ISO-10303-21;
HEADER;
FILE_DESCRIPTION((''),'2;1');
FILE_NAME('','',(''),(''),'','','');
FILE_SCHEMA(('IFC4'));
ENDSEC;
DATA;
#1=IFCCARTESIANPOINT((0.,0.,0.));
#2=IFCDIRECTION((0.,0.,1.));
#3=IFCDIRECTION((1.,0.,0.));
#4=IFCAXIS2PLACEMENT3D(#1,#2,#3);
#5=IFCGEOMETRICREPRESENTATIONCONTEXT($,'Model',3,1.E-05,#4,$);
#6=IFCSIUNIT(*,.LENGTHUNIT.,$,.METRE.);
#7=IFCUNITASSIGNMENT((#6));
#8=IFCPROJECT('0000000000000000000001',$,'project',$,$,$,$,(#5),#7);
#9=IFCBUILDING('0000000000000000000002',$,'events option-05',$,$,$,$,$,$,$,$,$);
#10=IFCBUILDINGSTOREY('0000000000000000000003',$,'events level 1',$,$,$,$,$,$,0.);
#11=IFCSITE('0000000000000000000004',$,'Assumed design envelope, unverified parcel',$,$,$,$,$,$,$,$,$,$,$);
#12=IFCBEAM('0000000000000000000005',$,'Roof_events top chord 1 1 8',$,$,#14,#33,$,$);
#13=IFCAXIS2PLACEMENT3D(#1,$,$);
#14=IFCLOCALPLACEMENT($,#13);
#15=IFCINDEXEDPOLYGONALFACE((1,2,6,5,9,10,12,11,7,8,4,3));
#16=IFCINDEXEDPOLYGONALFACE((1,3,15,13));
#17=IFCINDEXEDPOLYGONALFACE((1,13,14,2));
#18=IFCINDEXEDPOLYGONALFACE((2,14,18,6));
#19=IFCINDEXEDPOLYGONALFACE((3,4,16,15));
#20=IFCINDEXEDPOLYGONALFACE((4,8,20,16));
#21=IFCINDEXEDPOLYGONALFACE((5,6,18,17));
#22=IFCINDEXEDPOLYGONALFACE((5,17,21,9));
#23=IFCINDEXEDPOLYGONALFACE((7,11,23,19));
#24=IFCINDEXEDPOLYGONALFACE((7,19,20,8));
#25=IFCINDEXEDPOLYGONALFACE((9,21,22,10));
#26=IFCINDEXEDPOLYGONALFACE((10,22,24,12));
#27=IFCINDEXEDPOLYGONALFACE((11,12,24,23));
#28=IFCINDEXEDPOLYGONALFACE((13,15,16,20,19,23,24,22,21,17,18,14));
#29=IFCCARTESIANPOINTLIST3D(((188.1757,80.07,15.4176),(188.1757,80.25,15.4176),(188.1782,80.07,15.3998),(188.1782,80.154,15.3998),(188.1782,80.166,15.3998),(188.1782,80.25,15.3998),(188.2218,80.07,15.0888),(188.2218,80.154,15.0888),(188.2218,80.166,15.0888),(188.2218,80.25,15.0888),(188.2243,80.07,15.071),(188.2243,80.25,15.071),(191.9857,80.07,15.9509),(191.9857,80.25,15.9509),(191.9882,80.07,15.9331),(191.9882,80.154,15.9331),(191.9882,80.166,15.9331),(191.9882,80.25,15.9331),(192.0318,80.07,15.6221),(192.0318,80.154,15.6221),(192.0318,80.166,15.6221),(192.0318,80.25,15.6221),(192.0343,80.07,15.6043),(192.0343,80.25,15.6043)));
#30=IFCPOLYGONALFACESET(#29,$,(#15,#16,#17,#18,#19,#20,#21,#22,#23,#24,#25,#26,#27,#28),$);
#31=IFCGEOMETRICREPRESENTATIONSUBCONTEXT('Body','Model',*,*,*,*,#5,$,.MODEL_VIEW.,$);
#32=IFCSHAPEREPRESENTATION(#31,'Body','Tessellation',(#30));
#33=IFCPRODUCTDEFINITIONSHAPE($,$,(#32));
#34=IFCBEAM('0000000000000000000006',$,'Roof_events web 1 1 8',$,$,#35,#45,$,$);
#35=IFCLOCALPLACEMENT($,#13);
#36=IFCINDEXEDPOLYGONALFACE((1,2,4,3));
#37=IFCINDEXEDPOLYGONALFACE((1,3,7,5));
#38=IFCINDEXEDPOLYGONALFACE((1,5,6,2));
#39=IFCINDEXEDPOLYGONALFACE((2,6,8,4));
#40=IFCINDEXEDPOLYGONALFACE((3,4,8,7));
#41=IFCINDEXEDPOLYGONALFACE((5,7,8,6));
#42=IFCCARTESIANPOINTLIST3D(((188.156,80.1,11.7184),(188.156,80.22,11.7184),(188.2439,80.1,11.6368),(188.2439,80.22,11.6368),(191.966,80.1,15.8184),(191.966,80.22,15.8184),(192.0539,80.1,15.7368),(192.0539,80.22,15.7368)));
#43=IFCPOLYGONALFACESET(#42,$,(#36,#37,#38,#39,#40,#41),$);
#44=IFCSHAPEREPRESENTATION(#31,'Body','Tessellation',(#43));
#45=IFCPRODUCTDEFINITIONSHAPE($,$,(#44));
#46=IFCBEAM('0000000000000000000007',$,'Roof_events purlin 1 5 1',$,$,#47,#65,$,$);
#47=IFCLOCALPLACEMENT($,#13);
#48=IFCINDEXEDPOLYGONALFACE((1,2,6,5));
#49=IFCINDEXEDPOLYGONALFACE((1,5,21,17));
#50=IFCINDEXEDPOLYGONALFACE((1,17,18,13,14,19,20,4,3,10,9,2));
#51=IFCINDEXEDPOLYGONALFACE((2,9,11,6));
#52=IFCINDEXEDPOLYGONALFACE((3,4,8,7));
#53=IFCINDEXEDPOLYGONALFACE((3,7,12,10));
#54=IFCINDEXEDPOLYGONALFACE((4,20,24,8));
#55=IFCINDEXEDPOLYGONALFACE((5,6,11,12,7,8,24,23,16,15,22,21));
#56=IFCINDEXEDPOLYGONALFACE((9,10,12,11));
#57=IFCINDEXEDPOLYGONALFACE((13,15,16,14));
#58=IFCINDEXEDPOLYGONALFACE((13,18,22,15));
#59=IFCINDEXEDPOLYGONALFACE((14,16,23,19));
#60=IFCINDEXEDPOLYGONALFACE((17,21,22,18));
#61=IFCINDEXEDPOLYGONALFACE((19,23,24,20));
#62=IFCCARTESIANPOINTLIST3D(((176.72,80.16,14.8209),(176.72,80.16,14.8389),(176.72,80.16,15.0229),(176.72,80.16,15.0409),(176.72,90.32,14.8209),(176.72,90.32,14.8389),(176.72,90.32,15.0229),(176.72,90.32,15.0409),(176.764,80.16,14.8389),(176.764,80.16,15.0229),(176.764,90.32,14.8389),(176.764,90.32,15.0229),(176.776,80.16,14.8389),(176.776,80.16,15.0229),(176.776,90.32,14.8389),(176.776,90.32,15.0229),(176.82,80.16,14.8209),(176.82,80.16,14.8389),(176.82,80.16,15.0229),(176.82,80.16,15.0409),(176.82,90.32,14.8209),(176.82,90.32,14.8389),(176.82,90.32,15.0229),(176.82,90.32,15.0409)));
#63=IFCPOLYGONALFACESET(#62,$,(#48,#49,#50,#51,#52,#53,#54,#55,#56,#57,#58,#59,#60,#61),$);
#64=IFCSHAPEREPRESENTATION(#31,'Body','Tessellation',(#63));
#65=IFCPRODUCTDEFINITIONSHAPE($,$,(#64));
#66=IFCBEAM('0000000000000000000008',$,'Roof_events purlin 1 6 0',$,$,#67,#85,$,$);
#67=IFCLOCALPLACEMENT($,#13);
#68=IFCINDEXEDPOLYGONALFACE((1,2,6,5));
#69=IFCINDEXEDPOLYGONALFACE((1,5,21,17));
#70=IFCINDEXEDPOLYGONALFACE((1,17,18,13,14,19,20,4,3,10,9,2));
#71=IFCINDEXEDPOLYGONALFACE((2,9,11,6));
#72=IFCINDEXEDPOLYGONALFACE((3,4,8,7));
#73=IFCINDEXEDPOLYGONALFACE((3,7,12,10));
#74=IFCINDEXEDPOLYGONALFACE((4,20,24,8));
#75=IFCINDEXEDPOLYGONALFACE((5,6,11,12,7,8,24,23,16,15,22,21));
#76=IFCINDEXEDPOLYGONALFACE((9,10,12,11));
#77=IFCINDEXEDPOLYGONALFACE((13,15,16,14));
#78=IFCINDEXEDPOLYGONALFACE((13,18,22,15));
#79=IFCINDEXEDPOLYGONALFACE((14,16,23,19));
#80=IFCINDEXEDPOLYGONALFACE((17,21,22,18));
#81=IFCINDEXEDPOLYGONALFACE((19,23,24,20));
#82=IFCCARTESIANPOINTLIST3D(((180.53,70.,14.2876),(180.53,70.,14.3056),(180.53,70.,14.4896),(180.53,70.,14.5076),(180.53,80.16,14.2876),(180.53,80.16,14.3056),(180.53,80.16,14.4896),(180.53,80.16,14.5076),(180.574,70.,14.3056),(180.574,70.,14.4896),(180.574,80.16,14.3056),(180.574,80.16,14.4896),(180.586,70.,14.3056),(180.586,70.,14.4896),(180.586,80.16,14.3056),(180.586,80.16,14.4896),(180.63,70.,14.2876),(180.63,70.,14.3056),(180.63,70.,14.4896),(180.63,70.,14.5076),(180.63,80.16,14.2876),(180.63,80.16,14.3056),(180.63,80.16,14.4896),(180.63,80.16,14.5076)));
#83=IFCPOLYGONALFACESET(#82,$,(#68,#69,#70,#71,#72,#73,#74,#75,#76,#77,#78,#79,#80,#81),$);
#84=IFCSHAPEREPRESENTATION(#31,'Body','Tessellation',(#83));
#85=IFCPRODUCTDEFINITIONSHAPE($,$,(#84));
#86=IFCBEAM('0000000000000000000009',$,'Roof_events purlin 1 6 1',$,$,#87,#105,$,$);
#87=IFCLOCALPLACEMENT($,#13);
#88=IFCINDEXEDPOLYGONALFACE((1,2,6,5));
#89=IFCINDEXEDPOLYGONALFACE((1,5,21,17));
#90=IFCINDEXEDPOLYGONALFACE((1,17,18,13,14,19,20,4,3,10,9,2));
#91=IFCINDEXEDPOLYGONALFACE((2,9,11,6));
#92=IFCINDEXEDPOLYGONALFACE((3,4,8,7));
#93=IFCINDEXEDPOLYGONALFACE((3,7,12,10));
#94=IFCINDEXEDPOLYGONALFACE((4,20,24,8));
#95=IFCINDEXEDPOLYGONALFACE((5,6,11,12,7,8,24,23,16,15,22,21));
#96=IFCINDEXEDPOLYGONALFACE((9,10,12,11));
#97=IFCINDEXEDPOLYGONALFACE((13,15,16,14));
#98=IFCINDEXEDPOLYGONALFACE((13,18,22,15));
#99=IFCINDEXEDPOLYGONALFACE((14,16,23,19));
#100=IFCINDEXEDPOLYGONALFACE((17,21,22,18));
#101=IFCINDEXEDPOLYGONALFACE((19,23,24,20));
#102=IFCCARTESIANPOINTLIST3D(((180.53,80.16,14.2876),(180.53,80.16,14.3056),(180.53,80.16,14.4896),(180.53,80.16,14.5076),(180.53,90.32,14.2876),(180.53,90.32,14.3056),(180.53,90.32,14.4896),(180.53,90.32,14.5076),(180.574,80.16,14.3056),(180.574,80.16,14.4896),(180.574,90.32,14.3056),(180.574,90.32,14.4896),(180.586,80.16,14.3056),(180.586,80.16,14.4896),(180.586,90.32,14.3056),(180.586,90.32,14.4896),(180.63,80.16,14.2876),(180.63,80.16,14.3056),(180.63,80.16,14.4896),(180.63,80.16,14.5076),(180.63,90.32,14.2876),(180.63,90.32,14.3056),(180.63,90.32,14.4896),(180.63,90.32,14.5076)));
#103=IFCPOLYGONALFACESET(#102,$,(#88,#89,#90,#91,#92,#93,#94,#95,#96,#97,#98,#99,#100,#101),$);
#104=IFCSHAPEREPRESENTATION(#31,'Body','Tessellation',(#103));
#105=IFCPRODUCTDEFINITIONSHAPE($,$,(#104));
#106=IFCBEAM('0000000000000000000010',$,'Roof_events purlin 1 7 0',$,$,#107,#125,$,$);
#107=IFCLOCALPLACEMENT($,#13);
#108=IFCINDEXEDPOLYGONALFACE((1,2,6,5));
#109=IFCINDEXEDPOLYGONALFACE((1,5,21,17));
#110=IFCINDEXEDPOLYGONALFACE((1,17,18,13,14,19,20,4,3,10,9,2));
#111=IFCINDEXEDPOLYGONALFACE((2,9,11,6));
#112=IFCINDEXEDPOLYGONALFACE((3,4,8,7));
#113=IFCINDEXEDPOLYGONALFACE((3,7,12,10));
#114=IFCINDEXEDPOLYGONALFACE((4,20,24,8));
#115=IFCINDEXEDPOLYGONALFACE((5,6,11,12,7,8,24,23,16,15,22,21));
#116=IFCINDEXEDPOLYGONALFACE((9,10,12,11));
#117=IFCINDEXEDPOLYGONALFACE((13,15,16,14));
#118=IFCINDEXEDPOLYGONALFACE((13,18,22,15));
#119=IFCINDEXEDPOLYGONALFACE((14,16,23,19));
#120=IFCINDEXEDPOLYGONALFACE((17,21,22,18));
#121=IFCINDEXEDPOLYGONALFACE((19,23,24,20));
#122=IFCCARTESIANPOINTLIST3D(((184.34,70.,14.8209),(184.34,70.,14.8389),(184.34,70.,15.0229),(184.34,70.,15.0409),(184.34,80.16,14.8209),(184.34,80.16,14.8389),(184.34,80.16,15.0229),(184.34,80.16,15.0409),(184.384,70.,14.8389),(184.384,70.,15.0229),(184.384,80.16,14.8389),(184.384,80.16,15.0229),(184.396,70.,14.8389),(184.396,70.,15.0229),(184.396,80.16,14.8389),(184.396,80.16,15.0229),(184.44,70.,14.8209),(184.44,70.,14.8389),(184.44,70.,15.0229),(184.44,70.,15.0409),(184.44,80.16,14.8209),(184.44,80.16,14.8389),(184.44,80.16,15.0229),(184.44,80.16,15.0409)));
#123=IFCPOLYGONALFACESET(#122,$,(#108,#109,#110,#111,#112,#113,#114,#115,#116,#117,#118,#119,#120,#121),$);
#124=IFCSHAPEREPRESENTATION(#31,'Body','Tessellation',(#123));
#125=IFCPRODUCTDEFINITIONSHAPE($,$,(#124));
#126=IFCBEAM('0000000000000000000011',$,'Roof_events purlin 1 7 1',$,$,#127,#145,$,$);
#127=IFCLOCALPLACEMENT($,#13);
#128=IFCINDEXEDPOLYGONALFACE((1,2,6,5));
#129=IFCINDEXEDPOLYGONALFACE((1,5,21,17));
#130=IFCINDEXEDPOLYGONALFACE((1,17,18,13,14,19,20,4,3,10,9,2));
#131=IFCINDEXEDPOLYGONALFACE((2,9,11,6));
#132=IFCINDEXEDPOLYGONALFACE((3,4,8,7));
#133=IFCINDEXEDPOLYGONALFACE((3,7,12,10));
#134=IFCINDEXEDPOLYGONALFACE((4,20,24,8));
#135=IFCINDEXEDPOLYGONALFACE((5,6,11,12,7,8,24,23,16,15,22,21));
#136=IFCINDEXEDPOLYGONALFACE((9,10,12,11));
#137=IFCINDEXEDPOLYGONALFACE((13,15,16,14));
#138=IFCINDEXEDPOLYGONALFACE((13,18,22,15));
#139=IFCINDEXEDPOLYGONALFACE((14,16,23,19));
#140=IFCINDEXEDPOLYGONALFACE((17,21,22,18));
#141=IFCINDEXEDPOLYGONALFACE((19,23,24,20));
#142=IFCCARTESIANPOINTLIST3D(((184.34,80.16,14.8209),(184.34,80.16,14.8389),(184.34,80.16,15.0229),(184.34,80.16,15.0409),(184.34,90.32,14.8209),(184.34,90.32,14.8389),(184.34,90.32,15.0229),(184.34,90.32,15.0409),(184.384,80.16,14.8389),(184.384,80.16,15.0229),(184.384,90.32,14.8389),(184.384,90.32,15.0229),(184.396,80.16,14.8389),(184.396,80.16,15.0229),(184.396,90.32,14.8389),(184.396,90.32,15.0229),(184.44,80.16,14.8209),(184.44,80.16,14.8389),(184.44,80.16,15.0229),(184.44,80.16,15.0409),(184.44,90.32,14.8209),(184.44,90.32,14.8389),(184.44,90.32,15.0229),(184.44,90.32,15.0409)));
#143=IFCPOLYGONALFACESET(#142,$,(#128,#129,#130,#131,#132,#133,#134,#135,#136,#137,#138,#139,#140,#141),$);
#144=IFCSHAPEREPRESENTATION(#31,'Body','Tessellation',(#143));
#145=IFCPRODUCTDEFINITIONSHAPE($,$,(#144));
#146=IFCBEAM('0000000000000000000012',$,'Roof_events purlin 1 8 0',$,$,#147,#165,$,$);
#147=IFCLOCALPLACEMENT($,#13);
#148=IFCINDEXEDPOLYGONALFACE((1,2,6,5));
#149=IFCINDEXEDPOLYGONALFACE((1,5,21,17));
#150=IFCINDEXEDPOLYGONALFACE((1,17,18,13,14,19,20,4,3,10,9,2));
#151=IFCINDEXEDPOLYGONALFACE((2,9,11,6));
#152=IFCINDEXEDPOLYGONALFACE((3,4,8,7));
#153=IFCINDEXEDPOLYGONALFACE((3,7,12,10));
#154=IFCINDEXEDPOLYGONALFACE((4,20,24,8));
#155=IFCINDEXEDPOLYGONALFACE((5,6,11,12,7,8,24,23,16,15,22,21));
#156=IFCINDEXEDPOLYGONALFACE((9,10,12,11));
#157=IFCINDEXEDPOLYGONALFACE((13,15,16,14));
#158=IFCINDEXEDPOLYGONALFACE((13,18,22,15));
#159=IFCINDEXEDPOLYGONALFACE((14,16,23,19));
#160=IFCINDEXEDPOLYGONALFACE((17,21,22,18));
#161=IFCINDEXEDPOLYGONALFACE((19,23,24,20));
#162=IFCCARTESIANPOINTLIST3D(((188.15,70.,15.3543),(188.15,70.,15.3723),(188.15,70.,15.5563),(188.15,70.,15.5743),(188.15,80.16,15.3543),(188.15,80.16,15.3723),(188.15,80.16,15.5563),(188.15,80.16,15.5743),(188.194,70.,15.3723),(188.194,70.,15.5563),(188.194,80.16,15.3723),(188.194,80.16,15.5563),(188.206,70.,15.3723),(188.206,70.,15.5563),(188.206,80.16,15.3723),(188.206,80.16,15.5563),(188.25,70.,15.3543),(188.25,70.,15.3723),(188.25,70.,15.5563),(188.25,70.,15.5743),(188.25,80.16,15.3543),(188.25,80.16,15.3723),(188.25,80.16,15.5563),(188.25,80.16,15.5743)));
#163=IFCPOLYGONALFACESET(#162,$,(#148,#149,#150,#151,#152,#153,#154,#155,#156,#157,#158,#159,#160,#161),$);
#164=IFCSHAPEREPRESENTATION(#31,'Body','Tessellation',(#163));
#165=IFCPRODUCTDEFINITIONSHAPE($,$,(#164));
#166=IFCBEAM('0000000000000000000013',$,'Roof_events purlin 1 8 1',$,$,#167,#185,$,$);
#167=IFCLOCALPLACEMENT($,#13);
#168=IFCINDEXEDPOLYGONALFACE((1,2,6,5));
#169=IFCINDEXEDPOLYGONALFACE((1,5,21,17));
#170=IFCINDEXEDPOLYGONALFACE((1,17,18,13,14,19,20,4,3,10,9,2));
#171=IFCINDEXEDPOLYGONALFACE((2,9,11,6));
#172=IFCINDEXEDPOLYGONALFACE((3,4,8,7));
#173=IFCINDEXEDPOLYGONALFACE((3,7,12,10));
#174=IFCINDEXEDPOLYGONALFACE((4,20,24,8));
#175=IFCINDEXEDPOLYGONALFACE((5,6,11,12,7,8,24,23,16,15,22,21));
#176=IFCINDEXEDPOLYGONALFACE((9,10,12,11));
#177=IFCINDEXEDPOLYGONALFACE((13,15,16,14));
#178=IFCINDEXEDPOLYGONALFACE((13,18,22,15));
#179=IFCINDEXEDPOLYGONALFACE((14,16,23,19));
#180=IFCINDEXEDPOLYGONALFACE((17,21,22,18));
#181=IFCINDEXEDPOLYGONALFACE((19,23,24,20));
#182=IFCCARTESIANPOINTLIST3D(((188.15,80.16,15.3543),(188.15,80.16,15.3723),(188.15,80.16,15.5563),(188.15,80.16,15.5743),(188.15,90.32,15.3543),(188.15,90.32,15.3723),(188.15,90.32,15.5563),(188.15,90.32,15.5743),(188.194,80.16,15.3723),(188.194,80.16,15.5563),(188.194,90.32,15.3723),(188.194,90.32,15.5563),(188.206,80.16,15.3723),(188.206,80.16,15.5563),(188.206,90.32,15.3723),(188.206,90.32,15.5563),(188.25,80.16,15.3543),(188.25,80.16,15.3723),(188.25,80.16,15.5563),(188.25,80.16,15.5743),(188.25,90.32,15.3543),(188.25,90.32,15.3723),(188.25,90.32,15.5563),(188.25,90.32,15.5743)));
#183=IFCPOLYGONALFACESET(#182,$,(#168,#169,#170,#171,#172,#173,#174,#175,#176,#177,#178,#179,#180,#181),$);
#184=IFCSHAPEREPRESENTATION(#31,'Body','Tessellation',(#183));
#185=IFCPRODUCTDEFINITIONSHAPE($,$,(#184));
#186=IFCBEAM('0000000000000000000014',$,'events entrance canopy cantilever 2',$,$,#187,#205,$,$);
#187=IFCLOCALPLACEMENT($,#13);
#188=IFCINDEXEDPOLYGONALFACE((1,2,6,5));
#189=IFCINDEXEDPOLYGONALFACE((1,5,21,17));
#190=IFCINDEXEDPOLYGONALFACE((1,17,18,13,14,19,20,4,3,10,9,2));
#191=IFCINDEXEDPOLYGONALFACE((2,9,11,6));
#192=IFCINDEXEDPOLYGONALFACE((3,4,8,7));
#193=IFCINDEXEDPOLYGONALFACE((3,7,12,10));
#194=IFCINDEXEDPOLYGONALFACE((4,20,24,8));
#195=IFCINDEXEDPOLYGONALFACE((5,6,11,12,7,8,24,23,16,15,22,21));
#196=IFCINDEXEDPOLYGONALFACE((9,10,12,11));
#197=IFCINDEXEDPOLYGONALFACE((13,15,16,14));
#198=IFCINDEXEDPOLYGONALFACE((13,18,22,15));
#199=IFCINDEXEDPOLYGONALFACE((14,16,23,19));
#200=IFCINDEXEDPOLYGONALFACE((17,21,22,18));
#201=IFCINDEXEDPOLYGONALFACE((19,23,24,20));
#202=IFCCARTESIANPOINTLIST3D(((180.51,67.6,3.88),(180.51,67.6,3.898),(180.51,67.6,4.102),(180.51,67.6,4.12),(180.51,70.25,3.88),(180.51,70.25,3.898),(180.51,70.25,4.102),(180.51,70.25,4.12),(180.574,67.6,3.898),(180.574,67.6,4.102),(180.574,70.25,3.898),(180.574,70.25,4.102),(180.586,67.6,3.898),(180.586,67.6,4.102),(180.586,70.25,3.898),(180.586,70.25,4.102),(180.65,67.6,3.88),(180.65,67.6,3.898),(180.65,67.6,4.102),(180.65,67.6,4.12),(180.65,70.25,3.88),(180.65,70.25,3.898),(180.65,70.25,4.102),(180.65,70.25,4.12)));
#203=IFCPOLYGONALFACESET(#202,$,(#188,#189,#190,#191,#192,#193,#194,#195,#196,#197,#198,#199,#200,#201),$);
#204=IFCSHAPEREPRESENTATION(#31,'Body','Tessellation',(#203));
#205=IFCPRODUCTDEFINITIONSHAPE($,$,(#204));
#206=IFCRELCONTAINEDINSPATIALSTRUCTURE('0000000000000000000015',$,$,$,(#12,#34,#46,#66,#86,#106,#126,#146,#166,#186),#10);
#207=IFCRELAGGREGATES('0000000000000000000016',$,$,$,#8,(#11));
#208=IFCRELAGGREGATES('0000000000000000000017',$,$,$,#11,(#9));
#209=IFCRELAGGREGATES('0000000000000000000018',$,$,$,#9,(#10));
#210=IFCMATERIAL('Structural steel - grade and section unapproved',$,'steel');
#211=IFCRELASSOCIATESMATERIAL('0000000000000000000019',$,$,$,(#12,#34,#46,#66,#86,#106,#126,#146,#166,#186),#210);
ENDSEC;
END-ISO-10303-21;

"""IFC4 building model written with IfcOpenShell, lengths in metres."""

from ifc_helpers import new_model, si_unit, frame, origin_with_axes, place, context, subcontext, project, spatial, rectangle, i_section, extrude, material, element, save


model = new_model("IFC4")

# Units and contexts
model_context = context("Model", 3, precision=1e-05, world=origin_with_axes())
body_context = subcontext(model_context, "Body", "Model", "MODEL_VIEW")
ifc_project = project(units=[si_unit("LENGTHUNIT", "METRE")], contexts=[model_context])

# Site, building, storey
site = spatial("IfcSite", under=ifc_project, Name="Assumed design envelope, unverified parcel")
building = spatial("IfcBuilding", under=site, Name="events option-05")
storey = spatial("IfcBuildingStorey", under=building, Name="events level 1", Elevation=0.0)

# Beams
ifc_material_1 = material(Name="Structural steel - grade and section unapproved", Category="steel")
beam_1_placement = place(None, frame((188.2, 80.16, 15.2443), z_axis=(0.990344, 0.0, 0.138631), x_axis=(0.0, 1.0, 0.0)))
element("IfcBeam", 1, at=beam_1_placement, inside=storey, material=ifc_material_1, Name="Roof_events top chord 1 1 8", context=body_context, shape_type="SweptSolid", body=[
    extrude(i_section(OverallWidth=0.18, OverallDepth=0.35, WebThickness=0.012, FlangeThickness=0.018, FilletRadius=0.0), origin_with_axes(), (0.0, 0.0, 1.0), 3.8471),
])
beam_2_placement = place(None, frame((188.2, 80.16, 11.6776), z_axis=(0.680725, 0.0, 0.732539), x_axis=(0.0, 1.0, 0.0)))
element("IfcBeam", 2, at=beam_2_placement, inside=storey, material=ifc_material_1, Name="Roof_events web 1 1 8", context=body_context, shape_type="SweptSolid", body=[
    extrude(rectangle(XDim=0.12, YDim=0.12), origin_with_axes(), (0.0, 0.0, 1.0), 5.597),
])
beam_3_placement = place(None, frame((176.77, 80.16, 14.9309), z_axis=(0.0, 1.0, 0.0), x_axis=(-1.0, 0.0, 0.0)))
element("IfcBeam", 3, at=beam_3_placement, inside=storey, material=ifc_material_1, Name="Roof_events purlin 1 5 1", context=body_context, shape_type="SweptSolid", body=[
    extrude(i_section(OverallWidth=0.1, OverallDepth=0.22, WebThickness=0.012, FlangeThickness=0.018, FilletRadius=0.0), origin_with_axes(), (0.0, 0.0, 1.0), 10.16),
])
beam_4_placement = place(None, frame((180.58, 70.0, 14.3976), z_axis=(0.0, 1.0, 0.0), x_axis=(-1.0, 0.0, 0.0)))
element("IfcBeam", 4, at=beam_4_placement, inside=storey, material=ifc_material_1, Name="Roof_events purlin 1 6 0", context=body_context, shape_type="SweptSolid", body=[
    extrude(i_section(OverallWidth=0.1, OverallDepth=0.22, WebThickness=0.012, FlangeThickness=0.018, FilletRadius=0.0), origin_with_axes(), (0.0, 0.0, 1.0), 10.16),
])
beam_5_placement = place(None, frame((180.58, 80.16, 14.3976), z_axis=(0.0, 1.0, 0.0), x_axis=(-1.0, 0.0, 0.0)))
element("IfcBeam", 5, at=beam_5_placement, inside=storey, material=ifc_material_1, Name="Roof_events purlin 1 6 1", context=body_context, shape_type="SweptSolid", body=[
    extrude(i_section(OverallWidth=0.1, OverallDepth=0.22, WebThickness=0.012, FlangeThickness=0.018, FilletRadius=0.0), origin_with_axes(), (0.0, 0.0, 1.0), 10.16),
])
beam_6_placement = place(None, frame((184.39, 70.0, 14.9309), z_axis=(0.0, 1.0, 0.0), x_axis=(-1.0, 0.0, 0.0)))
element("IfcBeam", 6, at=beam_6_placement, inside=storey, material=ifc_material_1, Name="Roof_events purlin 1 7 0", context=body_context, shape_type="SweptSolid", body=[
    extrude(i_section(OverallWidth=0.1, OverallDepth=0.22, WebThickness=0.012, FlangeThickness=0.018, FilletRadius=0.0), origin_with_axes(), (0.0, 0.0, 1.0), 10.16),
])
beam_7_placement = place(None, frame((184.39, 80.16, 14.9309), z_axis=(0.0, 1.0, 0.0), x_axis=(-1.0, 0.0, 0.0)))
element("IfcBeam", 7, at=beam_7_placement, inside=storey, material=ifc_material_1, Name="Roof_events purlin 1 7 1", context=body_context, shape_type="SweptSolid", body=[
    extrude(i_section(OverallWidth=0.1, OverallDepth=0.22, WebThickness=0.012, FlangeThickness=0.018, FilletRadius=0.0), origin_with_axes(), (0.0, 0.0, 1.0), 10.16),
])
beam_8_placement = place(None, frame((188.2, 70.0, 15.4643), z_axis=(0.0, 1.0, 0.0), x_axis=(-1.0, 0.0, 0.0)))
element("IfcBeam", 8, at=beam_8_placement, inside=storey, material=ifc_material_1, Name="Roof_events purlin 1 8 0", context=body_context, shape_type="SweptSolid", body=[
    extrude(i_section(OverallWidth=0.1, OverallDepth=0.22, WebThickness=0.012, FlangeThickness=0.018, FilletRadius=0.0), origin_with_axes(), (0.0, 0.0, 1.0), 10.16),
])
beam_9_placement = place(None, frame((188.2, 80.16, 15.4643), z_axis=(0.0, 1.0, 0.0), x_axis=(-1.0, 0.0, 0.0)))
element("IfcBeam", 9, at=beam_9_placement, inside=storey, material=ifc_material_1, Name="Roof_events purlin 1 8 1", context=body_context, shape_type="SweptSolid", body=[
    extrude(i_section(OverallWidth=0.1, OverallDepth=0.22, WebThickness=0.012, FlangeThickness=0.018, FilletRadius=0.0), origin_with_axes(), (0.0, 0.0, 1.0), 10.16),
])
for number, where, z_axis, x_axis, name in (
    (10, (180.58, 70.25, 4.0), (0.0, -1.0, 0.0), (1.0, 0.0, 0.0), "events entrance canopy cantilever 2"),
):
    element("IfcBeam", number, at=place(None, frame(where, z_axis=z_axis, x_axis=x_axis)), inside=storey, material=ifc_material_1, Name=name, context=body_context, shape_type="SweptSolid", body=[
        extrude(i_section(OverallWidth=0.14, OverallDepth=0.24, WebThickness=0.012, FlangeThickness=0.018, FilletRadius=0.0), origin_with_axes(), (0.0, 0.0, 1.0), 2.65),
    ])

save(model, "model.ifc")
